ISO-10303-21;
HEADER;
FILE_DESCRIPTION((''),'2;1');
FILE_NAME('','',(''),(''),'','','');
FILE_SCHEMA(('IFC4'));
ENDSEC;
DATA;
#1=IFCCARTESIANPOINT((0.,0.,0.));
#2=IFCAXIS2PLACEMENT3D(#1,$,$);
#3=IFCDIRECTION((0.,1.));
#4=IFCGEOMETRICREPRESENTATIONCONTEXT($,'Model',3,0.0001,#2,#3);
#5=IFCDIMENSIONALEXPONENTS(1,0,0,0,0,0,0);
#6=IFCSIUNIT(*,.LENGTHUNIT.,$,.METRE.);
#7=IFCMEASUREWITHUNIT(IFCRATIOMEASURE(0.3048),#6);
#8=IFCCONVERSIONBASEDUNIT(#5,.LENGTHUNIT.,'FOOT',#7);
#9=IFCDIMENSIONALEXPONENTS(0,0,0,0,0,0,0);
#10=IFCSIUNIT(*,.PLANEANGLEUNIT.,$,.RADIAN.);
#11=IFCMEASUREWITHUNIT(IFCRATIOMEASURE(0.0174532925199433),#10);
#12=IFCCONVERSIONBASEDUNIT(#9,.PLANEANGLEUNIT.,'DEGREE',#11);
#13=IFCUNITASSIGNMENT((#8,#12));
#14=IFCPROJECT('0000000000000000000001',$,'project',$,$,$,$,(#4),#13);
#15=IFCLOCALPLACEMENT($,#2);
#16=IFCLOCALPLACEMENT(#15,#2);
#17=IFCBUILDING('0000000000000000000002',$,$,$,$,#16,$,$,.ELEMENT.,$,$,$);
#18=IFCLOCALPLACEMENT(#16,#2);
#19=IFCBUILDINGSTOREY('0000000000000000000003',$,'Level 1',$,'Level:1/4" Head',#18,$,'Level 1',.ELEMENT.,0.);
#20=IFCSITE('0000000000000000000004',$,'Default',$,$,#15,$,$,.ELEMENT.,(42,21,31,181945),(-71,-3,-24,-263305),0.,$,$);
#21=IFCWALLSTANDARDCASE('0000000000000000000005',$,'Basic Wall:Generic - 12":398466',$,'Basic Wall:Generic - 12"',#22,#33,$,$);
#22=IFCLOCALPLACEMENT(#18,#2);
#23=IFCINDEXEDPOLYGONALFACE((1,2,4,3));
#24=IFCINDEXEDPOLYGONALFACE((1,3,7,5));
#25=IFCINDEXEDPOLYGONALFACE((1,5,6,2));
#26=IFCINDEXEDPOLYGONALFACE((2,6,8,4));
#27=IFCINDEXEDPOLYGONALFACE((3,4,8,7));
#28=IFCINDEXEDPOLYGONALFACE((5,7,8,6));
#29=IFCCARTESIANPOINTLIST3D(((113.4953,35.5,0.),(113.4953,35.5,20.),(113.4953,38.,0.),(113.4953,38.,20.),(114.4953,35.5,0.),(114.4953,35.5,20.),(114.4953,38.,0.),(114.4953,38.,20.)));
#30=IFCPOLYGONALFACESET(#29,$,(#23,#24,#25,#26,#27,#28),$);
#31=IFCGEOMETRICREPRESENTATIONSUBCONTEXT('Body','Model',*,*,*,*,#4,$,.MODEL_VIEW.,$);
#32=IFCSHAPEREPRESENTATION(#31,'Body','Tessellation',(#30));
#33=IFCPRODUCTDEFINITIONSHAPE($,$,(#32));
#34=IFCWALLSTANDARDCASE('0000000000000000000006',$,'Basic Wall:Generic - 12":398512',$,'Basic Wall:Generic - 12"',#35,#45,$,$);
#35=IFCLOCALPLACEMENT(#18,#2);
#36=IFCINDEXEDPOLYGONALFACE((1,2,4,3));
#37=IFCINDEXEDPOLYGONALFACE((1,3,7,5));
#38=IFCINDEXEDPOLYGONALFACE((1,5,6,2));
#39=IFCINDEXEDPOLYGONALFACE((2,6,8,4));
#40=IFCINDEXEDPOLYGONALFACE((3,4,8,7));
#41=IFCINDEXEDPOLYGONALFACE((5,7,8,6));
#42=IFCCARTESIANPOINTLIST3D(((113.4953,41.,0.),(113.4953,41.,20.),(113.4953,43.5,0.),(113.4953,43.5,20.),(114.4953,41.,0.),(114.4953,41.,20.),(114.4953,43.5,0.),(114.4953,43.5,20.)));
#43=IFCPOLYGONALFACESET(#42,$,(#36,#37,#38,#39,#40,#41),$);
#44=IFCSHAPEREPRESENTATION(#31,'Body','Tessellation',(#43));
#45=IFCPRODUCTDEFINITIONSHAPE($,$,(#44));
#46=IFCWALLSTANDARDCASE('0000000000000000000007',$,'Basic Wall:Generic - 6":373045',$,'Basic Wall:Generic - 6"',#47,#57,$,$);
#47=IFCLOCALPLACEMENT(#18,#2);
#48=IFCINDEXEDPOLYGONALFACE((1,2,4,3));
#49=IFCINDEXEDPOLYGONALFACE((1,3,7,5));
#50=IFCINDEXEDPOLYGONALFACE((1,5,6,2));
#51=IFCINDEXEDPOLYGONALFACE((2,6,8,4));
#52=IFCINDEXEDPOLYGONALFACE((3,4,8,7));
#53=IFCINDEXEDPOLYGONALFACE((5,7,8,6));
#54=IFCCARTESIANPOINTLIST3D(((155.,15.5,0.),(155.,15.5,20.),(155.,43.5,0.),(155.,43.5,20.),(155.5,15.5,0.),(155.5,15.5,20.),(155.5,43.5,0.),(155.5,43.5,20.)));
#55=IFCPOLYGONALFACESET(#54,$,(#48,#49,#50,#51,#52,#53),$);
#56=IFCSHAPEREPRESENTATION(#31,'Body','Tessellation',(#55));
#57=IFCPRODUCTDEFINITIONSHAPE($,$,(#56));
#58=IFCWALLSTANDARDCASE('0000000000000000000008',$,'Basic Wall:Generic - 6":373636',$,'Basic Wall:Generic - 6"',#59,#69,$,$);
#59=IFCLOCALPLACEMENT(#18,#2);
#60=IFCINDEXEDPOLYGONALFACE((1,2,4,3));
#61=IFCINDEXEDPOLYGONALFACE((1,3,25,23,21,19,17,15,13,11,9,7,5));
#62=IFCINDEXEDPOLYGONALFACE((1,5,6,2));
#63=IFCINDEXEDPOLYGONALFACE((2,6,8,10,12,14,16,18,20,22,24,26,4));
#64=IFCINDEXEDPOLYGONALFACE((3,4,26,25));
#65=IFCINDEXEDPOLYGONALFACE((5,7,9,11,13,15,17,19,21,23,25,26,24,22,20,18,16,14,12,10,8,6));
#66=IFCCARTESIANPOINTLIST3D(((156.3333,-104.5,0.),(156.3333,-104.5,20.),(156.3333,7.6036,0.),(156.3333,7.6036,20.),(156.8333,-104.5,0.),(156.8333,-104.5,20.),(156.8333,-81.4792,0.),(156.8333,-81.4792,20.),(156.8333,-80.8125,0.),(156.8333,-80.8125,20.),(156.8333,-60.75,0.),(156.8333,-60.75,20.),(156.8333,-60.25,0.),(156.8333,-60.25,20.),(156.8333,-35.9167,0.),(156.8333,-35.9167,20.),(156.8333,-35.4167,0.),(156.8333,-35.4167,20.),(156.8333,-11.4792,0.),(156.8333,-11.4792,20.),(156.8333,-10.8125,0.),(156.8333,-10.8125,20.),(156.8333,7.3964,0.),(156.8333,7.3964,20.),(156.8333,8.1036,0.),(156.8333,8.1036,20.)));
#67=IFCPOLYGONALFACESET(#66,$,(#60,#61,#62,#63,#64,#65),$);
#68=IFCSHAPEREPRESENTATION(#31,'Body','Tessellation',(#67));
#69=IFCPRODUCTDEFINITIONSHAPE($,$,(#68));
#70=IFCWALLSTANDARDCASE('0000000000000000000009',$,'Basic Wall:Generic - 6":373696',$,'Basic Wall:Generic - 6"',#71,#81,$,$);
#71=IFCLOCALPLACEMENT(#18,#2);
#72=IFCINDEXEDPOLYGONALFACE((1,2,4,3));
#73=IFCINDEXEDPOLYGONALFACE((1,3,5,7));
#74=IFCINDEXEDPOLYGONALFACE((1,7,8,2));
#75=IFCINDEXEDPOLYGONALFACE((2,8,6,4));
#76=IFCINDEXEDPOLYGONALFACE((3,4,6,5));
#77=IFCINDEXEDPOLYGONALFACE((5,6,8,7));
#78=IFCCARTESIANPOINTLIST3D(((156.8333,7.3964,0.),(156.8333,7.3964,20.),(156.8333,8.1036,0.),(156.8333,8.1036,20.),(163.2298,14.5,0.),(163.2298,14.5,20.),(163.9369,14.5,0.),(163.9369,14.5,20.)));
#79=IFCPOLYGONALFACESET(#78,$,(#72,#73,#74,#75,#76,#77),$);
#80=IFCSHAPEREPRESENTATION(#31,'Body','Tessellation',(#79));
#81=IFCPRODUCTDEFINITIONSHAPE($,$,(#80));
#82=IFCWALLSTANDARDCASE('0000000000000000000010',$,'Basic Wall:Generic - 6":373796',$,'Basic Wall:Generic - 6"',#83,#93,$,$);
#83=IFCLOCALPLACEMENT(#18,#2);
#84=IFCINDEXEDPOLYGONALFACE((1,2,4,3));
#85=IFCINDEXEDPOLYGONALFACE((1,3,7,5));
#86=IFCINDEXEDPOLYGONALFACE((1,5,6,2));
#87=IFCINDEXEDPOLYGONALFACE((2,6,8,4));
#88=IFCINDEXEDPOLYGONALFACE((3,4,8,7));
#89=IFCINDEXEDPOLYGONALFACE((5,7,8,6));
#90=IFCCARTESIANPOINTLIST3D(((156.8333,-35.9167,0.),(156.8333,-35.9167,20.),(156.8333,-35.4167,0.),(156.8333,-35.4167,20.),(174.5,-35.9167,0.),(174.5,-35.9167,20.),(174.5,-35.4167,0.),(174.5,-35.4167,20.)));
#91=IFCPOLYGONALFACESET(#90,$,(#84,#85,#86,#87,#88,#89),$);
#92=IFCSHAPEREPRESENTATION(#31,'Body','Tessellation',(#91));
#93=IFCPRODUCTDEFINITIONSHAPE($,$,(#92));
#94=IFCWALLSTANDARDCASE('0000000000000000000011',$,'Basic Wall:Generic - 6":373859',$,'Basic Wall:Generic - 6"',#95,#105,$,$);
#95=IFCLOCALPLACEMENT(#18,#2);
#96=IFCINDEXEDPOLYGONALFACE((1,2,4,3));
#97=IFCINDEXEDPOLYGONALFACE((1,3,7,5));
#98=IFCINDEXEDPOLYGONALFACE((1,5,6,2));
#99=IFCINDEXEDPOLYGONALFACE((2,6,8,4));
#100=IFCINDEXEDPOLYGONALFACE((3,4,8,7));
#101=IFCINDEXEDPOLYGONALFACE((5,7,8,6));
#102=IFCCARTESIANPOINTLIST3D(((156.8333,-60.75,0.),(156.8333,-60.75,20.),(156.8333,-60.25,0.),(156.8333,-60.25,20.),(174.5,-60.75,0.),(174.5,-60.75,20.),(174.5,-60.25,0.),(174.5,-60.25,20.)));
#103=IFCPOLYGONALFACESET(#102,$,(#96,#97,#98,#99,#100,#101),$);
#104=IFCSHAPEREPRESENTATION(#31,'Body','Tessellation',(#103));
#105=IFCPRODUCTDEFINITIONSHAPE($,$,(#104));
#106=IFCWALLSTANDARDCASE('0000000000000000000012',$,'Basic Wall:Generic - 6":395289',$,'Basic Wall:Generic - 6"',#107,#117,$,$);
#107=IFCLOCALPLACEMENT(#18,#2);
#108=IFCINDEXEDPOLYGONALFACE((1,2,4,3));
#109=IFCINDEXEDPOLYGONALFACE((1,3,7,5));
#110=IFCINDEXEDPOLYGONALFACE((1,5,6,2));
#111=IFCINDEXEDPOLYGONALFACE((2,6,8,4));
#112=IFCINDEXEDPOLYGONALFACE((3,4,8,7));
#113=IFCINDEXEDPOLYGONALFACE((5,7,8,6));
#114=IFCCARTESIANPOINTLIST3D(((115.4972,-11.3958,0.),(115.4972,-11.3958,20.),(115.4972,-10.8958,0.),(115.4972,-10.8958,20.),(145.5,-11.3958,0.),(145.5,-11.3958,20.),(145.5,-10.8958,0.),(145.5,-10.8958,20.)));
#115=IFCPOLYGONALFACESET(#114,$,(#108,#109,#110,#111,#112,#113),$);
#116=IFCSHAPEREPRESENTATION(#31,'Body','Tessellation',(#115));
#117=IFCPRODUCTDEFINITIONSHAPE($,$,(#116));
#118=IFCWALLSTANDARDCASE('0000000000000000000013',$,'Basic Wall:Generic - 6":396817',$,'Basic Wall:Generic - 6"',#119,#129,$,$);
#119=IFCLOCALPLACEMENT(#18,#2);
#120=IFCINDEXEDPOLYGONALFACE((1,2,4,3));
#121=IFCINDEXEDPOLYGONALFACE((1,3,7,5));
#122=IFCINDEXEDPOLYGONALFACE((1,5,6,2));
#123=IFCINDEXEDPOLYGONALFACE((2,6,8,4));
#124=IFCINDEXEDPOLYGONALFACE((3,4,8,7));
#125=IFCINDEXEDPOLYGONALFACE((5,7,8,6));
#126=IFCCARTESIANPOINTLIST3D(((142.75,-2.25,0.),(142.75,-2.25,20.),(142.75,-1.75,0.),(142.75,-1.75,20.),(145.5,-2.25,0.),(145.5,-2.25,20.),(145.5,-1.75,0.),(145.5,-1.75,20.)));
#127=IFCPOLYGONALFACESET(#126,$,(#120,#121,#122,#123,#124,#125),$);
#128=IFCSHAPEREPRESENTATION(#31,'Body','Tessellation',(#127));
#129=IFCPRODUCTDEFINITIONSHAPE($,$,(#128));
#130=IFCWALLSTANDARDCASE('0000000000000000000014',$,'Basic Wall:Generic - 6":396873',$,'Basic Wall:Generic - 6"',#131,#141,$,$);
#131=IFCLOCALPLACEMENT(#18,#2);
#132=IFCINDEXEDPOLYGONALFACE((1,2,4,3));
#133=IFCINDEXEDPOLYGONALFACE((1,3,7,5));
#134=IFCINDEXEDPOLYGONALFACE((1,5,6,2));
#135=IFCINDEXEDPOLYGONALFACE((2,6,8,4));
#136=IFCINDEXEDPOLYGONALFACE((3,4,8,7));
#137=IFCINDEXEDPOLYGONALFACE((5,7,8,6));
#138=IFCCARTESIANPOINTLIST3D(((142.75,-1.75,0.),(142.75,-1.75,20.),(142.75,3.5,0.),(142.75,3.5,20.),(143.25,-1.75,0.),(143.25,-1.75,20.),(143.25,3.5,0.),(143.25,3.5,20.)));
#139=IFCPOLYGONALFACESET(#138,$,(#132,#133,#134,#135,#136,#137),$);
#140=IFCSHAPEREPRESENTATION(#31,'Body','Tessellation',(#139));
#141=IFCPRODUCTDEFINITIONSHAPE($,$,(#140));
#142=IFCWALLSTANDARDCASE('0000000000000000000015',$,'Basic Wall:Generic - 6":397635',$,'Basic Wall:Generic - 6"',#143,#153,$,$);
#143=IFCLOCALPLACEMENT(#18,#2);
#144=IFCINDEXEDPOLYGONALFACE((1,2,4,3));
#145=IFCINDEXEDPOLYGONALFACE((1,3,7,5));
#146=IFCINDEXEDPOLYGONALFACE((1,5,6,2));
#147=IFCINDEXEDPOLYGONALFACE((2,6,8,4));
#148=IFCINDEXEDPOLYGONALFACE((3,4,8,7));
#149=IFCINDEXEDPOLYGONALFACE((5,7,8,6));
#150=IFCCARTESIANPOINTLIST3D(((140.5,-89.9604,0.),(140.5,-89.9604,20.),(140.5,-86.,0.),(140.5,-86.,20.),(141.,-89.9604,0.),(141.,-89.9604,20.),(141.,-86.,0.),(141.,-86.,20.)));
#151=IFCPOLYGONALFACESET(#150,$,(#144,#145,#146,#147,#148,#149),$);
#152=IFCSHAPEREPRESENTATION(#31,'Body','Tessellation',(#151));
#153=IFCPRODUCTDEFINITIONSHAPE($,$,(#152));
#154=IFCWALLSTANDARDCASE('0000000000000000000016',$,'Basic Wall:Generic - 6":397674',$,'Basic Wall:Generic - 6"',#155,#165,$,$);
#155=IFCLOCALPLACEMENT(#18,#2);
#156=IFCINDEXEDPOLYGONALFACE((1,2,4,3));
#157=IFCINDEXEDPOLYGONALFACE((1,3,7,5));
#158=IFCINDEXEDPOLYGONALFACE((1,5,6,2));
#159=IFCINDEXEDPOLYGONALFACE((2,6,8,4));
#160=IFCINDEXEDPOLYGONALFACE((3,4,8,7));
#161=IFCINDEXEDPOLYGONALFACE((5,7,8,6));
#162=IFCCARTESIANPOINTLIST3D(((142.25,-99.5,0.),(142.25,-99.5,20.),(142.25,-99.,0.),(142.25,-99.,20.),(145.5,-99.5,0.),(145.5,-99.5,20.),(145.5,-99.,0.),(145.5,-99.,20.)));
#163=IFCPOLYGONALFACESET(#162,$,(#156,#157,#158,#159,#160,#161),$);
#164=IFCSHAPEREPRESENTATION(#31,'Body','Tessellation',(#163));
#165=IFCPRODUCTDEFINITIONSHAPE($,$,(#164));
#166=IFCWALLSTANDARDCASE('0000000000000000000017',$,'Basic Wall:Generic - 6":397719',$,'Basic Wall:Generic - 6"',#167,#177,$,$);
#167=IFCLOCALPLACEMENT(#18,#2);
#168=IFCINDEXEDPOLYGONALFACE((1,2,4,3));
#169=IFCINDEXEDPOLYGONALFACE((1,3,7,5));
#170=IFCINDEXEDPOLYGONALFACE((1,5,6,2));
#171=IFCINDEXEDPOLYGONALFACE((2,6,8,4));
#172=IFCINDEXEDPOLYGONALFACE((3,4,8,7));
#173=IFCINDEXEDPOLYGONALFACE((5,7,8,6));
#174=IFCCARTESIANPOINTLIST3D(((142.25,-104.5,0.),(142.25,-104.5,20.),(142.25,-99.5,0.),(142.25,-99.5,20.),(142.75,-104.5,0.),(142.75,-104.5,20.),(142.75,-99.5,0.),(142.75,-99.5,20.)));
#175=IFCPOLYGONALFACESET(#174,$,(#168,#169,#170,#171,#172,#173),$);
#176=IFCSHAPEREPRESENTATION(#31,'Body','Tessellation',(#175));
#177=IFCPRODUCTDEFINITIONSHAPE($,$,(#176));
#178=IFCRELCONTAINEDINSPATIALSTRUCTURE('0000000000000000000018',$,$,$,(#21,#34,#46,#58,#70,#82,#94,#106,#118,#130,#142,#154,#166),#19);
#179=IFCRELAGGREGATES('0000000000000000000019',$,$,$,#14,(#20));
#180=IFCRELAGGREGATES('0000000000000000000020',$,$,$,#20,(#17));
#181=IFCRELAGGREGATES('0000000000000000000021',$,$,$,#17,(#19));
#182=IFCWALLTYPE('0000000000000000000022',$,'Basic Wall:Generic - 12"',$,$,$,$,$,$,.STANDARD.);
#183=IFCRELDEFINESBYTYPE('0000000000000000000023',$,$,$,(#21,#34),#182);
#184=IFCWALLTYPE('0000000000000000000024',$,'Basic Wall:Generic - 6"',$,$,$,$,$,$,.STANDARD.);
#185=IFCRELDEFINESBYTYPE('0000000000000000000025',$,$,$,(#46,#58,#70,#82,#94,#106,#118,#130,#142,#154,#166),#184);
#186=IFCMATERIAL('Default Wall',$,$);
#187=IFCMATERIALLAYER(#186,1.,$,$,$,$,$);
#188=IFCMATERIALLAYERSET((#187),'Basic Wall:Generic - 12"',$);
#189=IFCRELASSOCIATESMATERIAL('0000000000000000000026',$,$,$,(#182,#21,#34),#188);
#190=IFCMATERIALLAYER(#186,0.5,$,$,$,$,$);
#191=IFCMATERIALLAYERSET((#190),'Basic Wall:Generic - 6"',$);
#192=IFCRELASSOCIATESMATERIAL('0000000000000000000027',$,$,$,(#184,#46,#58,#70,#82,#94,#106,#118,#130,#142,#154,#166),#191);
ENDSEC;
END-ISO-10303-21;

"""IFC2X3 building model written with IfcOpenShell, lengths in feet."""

from ifc_helpers import new_model, entity, si_unit, converted_unit, direction, frame, frame_2d, origin, place, context, subcontext, project, spatial, polyline, rectangle, outline, extrude, material, layer, layer_set, layer_usage, type_object, element, save


model = new_model("IFC2X3")

# Units and contexts
model_context = context("Model", 3, precision=0.0001, world=origin(), true_north=direction((0.0, 1.0)))
body_context = subcontext(model_context, "Body", "Model", "MODEL_VIEW")
ifc_project = project(units=[converted_unit("LENGTHUNIT", "FOOT", entity("IfcRatioMeasure", 0.3048), si_unit("LENGTHUNIT", "METRE"), dimensions=[1, 0, 0, 0, 0, 0, 0]), converted_unit("PLANEANGLEUNIT", "DEGREE", entity("IfcRatioMeasure", 0.0174532925199433), si_unit("PLANEANGLEUNIT", "RADIAN"), dimensions=[0, 0, 0, 0, 0, 0, 0])], contexts=[model_context])

# Site, building, storey
site_placement = place(None, origin())
site = spatial("IfcSite", under=ifc_project, at=site_placement, Name="Default", CompositionType="ELEMENT", RefLatitude=(42, 21, 31, 181945), RefLongitude=(-71, -3, -24, -263305), RefElevation=0.0)
building_placement = place(site_placement, origin())
building = spatial("IfcBuilding", under=site, at=building_placement, CompositionType="ELEMENT")
storey_placement = place(building_placement, origin())
storey = spatial("IfcBuildingStorey", under=building, at=storey_placement, Name="Level 1", ObjectType="Level:1/4\" Head", LongName="Level 1", CompositionType="ELEMENT", Elevation=0.0)

# Walls
ifc_material = material(Name="Default Wall")
ifc_layer_1 = layer(ifc_material, 1.0)
ifc_layer_set_1 = layer_set([ifc_layer_1], Name="Basic Wall:Generic - 12\"")
wall_type_1 = type_object("IfcWallType", Name="Basic Wall:Generic - 12\"", PredefinedType="STANDARD", material=ifc_layer_set_1)
ifc_layer_usage_1 = layer_usage(ifc_layer_set_1, "AXIS2", "NEGATIVE", 0.5)
wall_1_placement = place(storey_placement, frame((113.9953, 35.5, 0.0), z_axis=(0.0, 0.0, 1.0), x_axis=(0.0, 1.0, 0.0)))
element("IfcWallStandardCase", 1, at=wall_1_placement, inside=storey, type_object=wall_type_1, material=ifc_layer_usage_1, Name="Basic Wall:Generic - 12\":398466", ObjectType="Basic Wall:Generic - 12\"", context=body_context, shape_type="SweptSolid", body=[
    extrude(rectangle(XDim=2.5, YDim=1.0, at=frame_2d((1.25, 0.0), x_axis=(-1.0, 0.0))), origin(), (0.0, 0.0, 1.0), 20.0),
])
ifc_layer_usage_2 = layer_usage(ifc_layer_set_1, "AXIS2", "NEGATIVE", 0.5)
wall_2_placement = place(storey_placement, frame((113.9953, 43.5, 0.0), z_axis=(0.0, 0.0, 1.0), x_axis=(0.0, -1.0, 0.0)))
element("IfcWallStandardCase", 2, at=wall_2_placement, inside=storey, type_object=wall_type_1, material=ifc_layer_usage_2, Name="Basic Wall:Generic - 12\":398512", ObjectType="Basic Wall:Generic - 12\"", context=body_context, shape_type="SweptSolid", body=[
    extrude(rectangle(XDim=2.5, YDim=1.0, at=frame_2d((1.25, 0.0), x_axis=(-1.0, 0.0))), origin(), (0.0, 0.0, 1.0), 20.0),
])
ifc_layer_2 = layer(ifc_material, 0.5)
ifc_layer_set_2 = layer_set([ifc_layer_2], Name="Basic Wall:Generic - 6\"")
ifc_layer_usage_3 = layer_usage(ifc_layer_set_2, "AXIS2", "NEGATIVE", 0.25)
wall_type_2 = type_object("IfcWallType", Name="Basic Wall:Generic - 6\"", PredefinedType="STANDARD", material=ifc_layer_set_2)
wall_3_placement = place(storey_placement, frame((155.25, 15.5, 0.0), z_axis=(0.0, 0.0, 1.0), x_axis=(0.0, 1.0, 0.0)))
element("IfcWallStandardCase", 3, at=wall_3_placement, inside=storey, type_object=wall_type_2, material=ifc_layer_usage_3, Name="Basic Wall:Generic - 6\":373045", ObjectType="Basic Wall:Generic - 6\"", context=body_context, shape_type="SweptSolid", body=[
    extrude(rectangle(XDim=28.0, YDim=0.5, at=frame_2d((14.0, 0.0), x_axis=(-1.0, 0.0))), origin(), (0.0, 0.0, 1.0), 20.0),
])
ifc_layer_usage_4 = layer_usage(ifc_layer_set_2, "AXIS2", "NEGATIVE", 0.25)
wall_4_placement = place(storey_placement, frame((156.5833, -104.5, 0.0), z_axis=(0.0, 0.0, 1.0), x_axis=(0.0, 1.0, 0.0)))
element("IfcWallStandardCase", 4, at=wall_4_placement, inside=storey, type_object=wall_type_2, material=ifc_layer_usage_4, Name="Basic Wall:Generic - 6\":373636", ObjectType="Basic Wall:Generic - 6\"", context=body_context, shape_type="SweptSolid", body=[
    extrude(outline(polyline([(112.6036, -0.25), (112.1036, 0.25), (0.0, 0.25), (0.0, -0.25), (23.0208, -0.25), (23.6875, -0.25), (43.75, -0.25), (44.25, -0.25), (68.5833, -0.25), (69.0833, -0.25), (93.0208, -0.25), (93.6875, -0.25), (111.8964, -0.25), (112.6036, -0.25)])), origin(), (0.0, 0.0, 1.0), 20.0),
])
ifc_layer_usage_5 = layer_usage(ifc_layer_set_2, "AXIS2", "NEGATIVE", 0.25)
wall_5_placement = place(storey_placement, frame((156.6566, 7.5732, 0.0), z_axis=(0.0, 0.0, 1.0), x_axis=(0.707107, 0.707107, 0.0)))
element("IfcWallStandardCase", 5, at=wall_5_placement, inside=storey, type_object=wall_type_2, material=ifc_layer_usage_5, Name="Basic Wall:Generic - 6\":373696", ObjectType="Basic Wall:Generic - 6\"", context=body_context, shape_type="SweptSolid", body=[
    extrude(outline(polyline([(10.0459, -0.25), (9.5459, 0.25), (0.5, 0.25), (0.0, -0.25), (10.0459, -0.25)])), origin(), (0.0, 0.0, 1.0), 20.0),
])
ifc_layer_usage_6 = layer_usage(ifc_layer_set_2, "AXIS2", "NEGATIVE", 0.25)
wall_6_placement = place(storey_placement, frame((156.8333, -35.6667, 0.0)))
element("IfcWallStandardCase", 6, at=wall_6_placement, inside=storey, type_object=wall_type_2, material=ifc_layer_usage_6, Name="Basic Wall:Generic - 6\":373796", ObjectType="Basic Wall:Generic - 6\"", context=body_context, shape_type="SweptSolid", body=[
    extrude(rectangle(XDim=17.6667, YDim=0.5, at=frame_2d((8.8333, 0.0), x_axis=(-1.0, 0.0))), origin(), (0.0, 0.0, 1.0), 20.0),
])
ifc_layer_usage_7 = layer_usage(ifc_layer_set_2, "AXIS2", "NEGATIVE", 0.25)
wall_7_placement = place(storey_placement, frame((174.5, -60.5, 0.0), z_axis=(0.0, 0.0, 1.0), x_axis=(-1.0, 0.0, 0.0)))
element("IfcWallStandardCase", 7, at=wall_7_placement, inside=storey, type_object=wall_type_2, material=ifc_layer_usage_7, Name="Basic Wall:Generic - 6\":373859", ObjectType="Basic Wall:Generic - 6\"", context=body_context, shape_type="SweptSolid", body=[
    extrude(rectangle(XDim=17.6667, YDim=0.5, at=frame_2d((8.8333, 0.0), x_axis=(-1.0, 0.0))), origin(), (0.0, 0.0, 1.0), 20.0),
])
ifc_layer_usage_8 = layer_usage(ifc_layer_set_2, "AXIS2", "NEGATIVE", 0.25)
wall_8_placement = place(storey_placement, frame((115.4972, -11.1458, 0.0)))
element("IfcWallStandardCase", 8, at=wall_8_placement, inside=storey, type_object=wall_type_2, material=ifc_layer_usage_8, Name="Basic Wall:Generic - 6\":395289", ObjectType="Basic Wall:Generic - 6\"", context=body_context, shape_type="SweptSolid", body=[
    extrude(rectangle(XDim=30.0028, YDim=0.5, at=frame_2d((15.0014, 0.0), x_axis=(-1.0, 0.0))), origin(), (0.0, 0.0, 1.0), 20.0),
])
ifc_layer_usage_9 = layer_usage(ifc_layer_set_2, "AXIS2", "NEGATIVE", 0.25)
wall_9_placement = place(storey_placement, frame((145.5, -2.0, 0.0), z_axis=(0.0, 0.0, 1.0), x_axis=(-1.0, 0.0, 0.0)))
element("IfcWallStandardCase", 9, at=wall_9_placement, inside=storey, type_object=wall_type_2, material=ifc_layer_usage_9, Name="Basic Wall:Generic - 6\":396817", ObjectType="Basic Wall:Generic - 6\"", context=body_context, shape_type="SweptSolid", body=[
    extrude(rectangle(XDim=2.75, YDim=0.5, at=frame_2d((1.375, 0.0), x_axis=(-1.0, 0.0))), origin(), (0.0, 0.0, 1.0), 20.0),
])
ifc_layer_usage_10 = layer_usage(ifc_layer_set_2, "AXIS2", "NEGATIVE", 0.25)
wall_10_placement = place(storey_placement, frame((143.0, -1.75, 0.0), z_axis=(0.0, 0.0, 1.0), x_axis=(0.0, 1.0, 0.0)))
element("IfcWallStandardCase", 10, at=wall_10_placement, inside=storey, type_object=wall_type_2, material=ifc_layer_usage_10, Name="Basic Wall:Generic - 6\":396873", ObjectType="Basic Wall:Generic - 6\"", context=body_context, shape_type="SweptSolid", body=[
    extrude(rectangle(XDim=5.25, YDim=0.5, at=frame_2d((2.625, 0.0), x_axis=(-1.0, 0.0))), origin(), (0.0, 0.0, 1.0), 20.0),
])
ifc_layer_usage_11 = layer_usage(ifc_layer_set_2, "AXIS2", "NEGATIVE", 0.25)
wall_11_placement = place(storey_placement, frame((140.75, -86.0, 0.0), z_axis=(0.0, 0.0, 1.0), x_axis=(0.0, -1.0, 0.0)))
element("IfcWallStandardCase", 11, at=wall_11_placement, inside=storey, type_object=wall_type_2, material=ifc_layer_usage_11, Name="Basic Wall:Generic - 6\":397635", ObjectType="Basic Wall:Generic - 6\"", context=body_context, shape_type="SweptSolid", body=[
    extrude(rectangle(XDim=3.9604, YDim=0.5, at=frame_2d((1.9802, 0.0), x_axis=(-1.0, 0.0))), origin(), (0.0, 0.0, 1.0), 20.0),
])
ifc_layer_usage_12 = layer_usage(ifc_layer_set_2, "AXIS2", "NEGATIVE", 0.25)
wall_12_placement = place(storey_placement, frame((145.5, -99.25, 0.0), z_axis=(0.0, 0.0, 1.0), x_axis=(-1.0, 0.0, 0.0)))
element("IfcWallStandardCase", 12, at=wall_12_placement, inside=storey, type_object=wall_type_2, material=ifc_layer_usage_12, Name="Basic Wall:Generic - 6\":397674", ObjectType="Basic Wall:Generic - 6\"", context=body_context, shape_type="SweptSolid", body=[
    extrude(rectangle(XDim=3.25, YDim=0.5, at=frame_2d((1.625, 0.0), x_axis=(-1.0, 0.0))), origin(), (0.0, 0.0, 1.0), 20.0),
])
ifc_layer_usage_13 = layer_usage(ifc_layer_set_2, "AXIS2", "NEGATIVE", 0.25)
wall_13_placement = place(storey_placement, frame((142.5, -99.5, 0.0), z_axis=(0.0, 0.0, 1.0), x_axis=(0.0, -1.0, 0.0)))
element("IfcWallStandardCase", 13, at=wall_13_placement, inside=storey, type_object=wall_type_2, material=ifc_layer_usage_13, Name="Basic Wall:Generic - 6\":397719", ObjectType="Basic Wall:Generic - 6\"", context=body_context, shape_type="SweptSolid", body=[
    extrude(rectangle(XDim=5.0, YDim=0.5, at=frame_2d((2.5, 0.0), x_axis=(-1.0, 0.0))), origin(), (0.0, 0.0, 1.0), 20.0),
])

save(model, "model.ifc")
